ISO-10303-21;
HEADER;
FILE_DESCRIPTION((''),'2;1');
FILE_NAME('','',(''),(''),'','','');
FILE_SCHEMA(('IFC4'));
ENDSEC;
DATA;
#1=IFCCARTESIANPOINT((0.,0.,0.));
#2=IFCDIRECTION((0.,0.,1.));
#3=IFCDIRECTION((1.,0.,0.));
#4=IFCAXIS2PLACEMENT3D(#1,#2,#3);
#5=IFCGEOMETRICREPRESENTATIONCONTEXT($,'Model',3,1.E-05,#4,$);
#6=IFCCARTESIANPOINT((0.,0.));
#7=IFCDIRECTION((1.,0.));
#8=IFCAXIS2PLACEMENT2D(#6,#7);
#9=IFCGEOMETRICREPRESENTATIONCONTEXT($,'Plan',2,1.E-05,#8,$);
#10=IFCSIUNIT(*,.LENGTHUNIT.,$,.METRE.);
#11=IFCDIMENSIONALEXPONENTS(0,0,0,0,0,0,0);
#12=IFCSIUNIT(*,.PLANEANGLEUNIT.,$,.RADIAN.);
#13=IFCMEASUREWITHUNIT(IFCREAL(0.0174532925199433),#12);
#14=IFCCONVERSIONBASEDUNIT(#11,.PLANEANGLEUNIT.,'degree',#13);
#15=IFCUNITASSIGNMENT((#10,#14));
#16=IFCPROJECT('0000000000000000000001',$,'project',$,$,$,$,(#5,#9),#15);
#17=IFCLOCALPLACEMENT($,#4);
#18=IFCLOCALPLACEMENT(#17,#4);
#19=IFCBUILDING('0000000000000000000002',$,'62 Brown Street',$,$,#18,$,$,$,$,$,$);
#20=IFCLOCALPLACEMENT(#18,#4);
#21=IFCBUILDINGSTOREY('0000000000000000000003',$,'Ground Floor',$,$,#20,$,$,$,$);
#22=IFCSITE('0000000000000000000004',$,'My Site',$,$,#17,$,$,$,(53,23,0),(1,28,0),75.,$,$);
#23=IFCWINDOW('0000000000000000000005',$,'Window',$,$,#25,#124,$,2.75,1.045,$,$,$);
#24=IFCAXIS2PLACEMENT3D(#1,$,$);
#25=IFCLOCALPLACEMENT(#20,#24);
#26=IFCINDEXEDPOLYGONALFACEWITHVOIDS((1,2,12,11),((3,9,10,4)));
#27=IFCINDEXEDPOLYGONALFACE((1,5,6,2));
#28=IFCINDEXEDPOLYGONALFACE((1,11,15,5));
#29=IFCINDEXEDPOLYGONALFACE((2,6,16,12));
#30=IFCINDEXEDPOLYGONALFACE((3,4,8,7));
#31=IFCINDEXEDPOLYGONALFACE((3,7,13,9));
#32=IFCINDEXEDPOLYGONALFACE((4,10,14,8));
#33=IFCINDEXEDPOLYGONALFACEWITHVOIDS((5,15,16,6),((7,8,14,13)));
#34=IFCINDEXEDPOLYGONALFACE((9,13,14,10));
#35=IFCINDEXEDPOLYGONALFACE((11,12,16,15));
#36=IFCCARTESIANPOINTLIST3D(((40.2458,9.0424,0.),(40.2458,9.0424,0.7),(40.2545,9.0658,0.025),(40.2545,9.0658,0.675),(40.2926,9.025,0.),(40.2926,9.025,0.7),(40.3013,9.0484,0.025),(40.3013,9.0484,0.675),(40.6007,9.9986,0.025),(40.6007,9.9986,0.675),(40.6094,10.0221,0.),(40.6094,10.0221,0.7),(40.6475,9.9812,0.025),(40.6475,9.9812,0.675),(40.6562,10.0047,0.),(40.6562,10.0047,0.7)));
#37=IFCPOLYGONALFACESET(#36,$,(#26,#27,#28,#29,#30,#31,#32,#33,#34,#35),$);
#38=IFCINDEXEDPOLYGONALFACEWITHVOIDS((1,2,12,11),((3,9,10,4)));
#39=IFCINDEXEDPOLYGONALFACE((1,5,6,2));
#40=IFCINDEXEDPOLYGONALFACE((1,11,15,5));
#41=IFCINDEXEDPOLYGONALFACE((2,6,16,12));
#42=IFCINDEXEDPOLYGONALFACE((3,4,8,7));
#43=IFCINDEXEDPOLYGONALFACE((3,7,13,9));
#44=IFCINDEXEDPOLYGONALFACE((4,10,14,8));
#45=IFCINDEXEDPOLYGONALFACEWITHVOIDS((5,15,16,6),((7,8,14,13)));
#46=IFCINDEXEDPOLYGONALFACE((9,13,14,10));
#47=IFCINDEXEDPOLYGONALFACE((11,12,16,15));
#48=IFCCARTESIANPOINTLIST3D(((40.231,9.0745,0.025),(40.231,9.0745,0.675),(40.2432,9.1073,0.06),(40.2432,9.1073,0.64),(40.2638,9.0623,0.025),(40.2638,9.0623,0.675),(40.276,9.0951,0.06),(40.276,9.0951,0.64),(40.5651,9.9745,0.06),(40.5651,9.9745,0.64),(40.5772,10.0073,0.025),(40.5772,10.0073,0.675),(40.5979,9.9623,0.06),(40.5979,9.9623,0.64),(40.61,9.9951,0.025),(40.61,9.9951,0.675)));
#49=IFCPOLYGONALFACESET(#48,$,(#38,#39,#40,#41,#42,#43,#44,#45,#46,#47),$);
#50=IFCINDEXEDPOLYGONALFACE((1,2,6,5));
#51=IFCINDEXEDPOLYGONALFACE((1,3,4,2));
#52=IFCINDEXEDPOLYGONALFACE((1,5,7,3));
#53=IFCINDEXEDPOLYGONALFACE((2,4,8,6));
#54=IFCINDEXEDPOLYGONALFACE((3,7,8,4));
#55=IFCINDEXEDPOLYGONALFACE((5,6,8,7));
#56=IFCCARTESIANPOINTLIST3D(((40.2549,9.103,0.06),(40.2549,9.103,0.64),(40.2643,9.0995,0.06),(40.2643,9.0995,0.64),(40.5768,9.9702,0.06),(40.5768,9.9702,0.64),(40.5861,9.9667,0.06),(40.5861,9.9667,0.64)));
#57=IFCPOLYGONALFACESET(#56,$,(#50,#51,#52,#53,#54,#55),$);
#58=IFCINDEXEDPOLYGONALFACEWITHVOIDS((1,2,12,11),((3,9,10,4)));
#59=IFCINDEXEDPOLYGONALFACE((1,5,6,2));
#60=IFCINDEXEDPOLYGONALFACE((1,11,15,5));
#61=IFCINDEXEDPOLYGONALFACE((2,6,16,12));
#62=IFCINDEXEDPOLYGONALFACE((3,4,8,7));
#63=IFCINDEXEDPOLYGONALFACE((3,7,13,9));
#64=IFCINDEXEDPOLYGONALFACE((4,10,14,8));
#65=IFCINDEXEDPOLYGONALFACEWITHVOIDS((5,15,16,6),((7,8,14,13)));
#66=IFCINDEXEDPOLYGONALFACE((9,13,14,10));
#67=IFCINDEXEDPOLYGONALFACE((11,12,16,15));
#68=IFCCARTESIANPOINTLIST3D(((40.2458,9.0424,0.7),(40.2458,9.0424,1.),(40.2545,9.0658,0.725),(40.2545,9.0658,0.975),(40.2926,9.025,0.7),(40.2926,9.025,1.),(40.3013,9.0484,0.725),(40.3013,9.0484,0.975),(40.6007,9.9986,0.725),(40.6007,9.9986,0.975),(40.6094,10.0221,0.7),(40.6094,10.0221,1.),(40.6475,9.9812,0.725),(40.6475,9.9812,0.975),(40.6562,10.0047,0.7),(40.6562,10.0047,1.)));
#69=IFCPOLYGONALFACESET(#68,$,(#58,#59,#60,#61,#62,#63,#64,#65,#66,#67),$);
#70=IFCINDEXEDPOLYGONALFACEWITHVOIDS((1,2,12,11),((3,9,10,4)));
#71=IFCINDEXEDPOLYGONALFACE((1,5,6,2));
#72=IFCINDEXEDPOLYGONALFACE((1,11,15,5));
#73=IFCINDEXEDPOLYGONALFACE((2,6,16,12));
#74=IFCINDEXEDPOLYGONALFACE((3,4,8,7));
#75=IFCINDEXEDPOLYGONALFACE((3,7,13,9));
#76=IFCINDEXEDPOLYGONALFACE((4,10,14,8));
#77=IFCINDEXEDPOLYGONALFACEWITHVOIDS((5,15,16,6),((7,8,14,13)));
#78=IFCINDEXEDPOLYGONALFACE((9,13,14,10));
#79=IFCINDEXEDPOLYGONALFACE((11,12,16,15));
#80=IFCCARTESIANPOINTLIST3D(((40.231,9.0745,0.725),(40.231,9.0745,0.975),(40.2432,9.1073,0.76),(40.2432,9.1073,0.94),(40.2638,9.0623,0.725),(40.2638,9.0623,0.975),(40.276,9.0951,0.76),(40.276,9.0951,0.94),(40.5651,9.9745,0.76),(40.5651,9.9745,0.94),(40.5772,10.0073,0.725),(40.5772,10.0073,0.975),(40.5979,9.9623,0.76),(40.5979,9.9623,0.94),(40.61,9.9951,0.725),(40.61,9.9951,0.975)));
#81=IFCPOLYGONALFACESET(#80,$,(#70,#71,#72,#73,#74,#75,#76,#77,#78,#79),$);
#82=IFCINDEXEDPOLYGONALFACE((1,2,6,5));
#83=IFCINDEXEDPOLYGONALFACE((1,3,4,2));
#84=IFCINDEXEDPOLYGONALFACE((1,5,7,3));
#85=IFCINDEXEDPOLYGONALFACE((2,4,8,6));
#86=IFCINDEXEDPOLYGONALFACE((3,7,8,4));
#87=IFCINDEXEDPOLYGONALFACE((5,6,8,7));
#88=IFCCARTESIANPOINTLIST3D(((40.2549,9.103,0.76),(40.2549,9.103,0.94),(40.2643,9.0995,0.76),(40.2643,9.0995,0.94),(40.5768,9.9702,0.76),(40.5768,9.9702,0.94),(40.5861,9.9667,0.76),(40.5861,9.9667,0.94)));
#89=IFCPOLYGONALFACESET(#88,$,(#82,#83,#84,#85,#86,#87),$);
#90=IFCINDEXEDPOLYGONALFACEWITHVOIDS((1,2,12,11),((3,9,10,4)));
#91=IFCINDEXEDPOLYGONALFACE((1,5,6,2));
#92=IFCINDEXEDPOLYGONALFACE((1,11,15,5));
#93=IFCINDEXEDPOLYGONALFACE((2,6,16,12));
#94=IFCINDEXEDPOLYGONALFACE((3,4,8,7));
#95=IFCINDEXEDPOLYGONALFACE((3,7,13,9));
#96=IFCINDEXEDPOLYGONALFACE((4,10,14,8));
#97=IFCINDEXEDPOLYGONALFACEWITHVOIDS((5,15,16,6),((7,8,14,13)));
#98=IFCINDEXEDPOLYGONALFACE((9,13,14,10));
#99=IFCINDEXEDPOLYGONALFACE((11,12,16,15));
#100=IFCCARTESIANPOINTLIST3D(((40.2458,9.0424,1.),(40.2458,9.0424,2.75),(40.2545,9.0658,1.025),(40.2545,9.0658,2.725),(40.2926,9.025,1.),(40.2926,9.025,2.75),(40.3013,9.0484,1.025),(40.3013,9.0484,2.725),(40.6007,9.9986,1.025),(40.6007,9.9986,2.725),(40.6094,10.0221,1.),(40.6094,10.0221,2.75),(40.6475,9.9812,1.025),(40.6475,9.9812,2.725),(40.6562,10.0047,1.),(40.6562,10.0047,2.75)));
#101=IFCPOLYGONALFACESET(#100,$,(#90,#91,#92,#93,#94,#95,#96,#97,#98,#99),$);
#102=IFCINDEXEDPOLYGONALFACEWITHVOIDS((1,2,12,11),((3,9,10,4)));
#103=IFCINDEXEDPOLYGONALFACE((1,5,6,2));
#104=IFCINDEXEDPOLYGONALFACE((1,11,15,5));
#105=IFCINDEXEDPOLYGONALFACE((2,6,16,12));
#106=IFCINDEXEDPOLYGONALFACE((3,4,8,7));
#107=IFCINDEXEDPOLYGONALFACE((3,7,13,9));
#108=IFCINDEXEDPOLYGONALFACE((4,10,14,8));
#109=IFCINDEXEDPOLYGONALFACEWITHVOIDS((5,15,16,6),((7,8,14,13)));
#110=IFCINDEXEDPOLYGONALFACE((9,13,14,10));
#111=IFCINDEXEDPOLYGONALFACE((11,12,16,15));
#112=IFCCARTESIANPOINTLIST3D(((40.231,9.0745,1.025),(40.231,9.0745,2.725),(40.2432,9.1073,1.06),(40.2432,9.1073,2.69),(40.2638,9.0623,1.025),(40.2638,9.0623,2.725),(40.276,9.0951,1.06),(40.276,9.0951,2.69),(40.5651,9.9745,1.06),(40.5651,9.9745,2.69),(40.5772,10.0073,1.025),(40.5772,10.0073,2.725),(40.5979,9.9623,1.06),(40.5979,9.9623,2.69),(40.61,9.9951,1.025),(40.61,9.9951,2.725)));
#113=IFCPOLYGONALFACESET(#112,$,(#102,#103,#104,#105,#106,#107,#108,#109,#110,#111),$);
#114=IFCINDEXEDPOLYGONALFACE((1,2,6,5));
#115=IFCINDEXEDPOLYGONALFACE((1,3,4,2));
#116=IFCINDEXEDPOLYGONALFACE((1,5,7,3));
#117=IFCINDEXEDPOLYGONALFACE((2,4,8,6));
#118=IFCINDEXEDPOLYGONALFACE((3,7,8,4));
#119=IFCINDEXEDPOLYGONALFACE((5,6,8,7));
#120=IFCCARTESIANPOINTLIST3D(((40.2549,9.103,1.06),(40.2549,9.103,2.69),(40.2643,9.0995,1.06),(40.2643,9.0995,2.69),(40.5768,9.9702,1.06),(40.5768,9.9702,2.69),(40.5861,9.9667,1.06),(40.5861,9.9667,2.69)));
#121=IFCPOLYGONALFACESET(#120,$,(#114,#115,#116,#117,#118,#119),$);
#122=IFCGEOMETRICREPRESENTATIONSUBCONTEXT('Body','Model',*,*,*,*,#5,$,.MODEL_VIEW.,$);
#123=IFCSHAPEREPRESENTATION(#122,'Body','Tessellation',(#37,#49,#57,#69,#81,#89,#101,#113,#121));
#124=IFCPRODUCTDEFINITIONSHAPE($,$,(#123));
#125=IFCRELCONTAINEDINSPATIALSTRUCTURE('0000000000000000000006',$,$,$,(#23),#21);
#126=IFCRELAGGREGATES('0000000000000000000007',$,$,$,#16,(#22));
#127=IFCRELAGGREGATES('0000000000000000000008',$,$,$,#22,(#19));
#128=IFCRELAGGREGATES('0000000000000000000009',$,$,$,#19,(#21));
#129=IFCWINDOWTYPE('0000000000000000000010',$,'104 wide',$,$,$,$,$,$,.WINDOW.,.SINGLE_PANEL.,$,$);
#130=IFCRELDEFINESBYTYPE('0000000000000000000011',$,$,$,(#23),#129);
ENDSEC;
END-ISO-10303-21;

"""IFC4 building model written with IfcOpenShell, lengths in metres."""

from ifc_helpers import new_model, entity, si_unit, converted_unit, frame, origin_with_axes, origin_2d_with_axis, place, context, subcontext, project, spatial, line, indexed_curve, outline, extrude, shape, source, transform, mapped, type_object, type_shapes, element, save


model = new_model("IFC4")

# Units and contexts
model_context = context("Model", 3, precision=1e-05, world=origin_with_axes())
plan_context = context("Plan", 2, precision=1e-05, world=origin_2d_with_axis())
body_context_1 = subcontext(model_context, "Body", "Model", "MODEL_VIEW")
body_context_2 = subcontext(plan_context, "Body", "Plan", "PLAN_VIEW")
ifc_project = project(units=[si_unit("LENGTHUNIT", "METRE"), converted_unit("PLANEANGLEUNIT", "degree", entity("IfcReal", 0.0174532925199433), si_unit("PLANEANGLEUNIT", "RADIAN"), dimensions=[0, 0, 0, 0, 0, 0, 0])], contexts=[model_context, plan_context])

# Site, building, storey
site_placement = place(None, origin_with_axes())
site = spatial("IfcSite", under=ifc_project, at=site_placement, Name="My Site", RefLatitude=(53, 23, 0), RefLongitude=(1, 28, 0), RefElevation=75.0)
building_placement = place(site_placement, origin_with_axes())
building = spatial("IfcBuilding", under=site, at=building_placement, Name="62 Brown Street")
storey_placement = place(building_placement, origin_with_axes())
storey = spatial("IfcBuildingStorey", under=building, at=storey_placement, Name="Ground Floor")

# Window
window_type_1 = type_object("IfcWindowType", Name="104 wide", PartitioningType="SINGLE_PANEL", PredefinedType="WINDOW")
shared_shape_1 = source(origin_with_axes(), body_context_1, "Body", "SweptSolid", [
    extrude(outline(indexed_curve([(0.0, 0.0), (1.045, 0.0), (1.045, 0.7), (0.0, 0.7)], segments=[line(1, 2, 3, 4, 1)]), holes=[indexed_curve([(0.025, 0.025), (1.02, 0.025), (1.02, 0.675), (0.025, 0.675)], segments=[line(1, 2, 3, 4, 1)])]), frame((0.0, 0.15, 0.0), z_axis=(0.0, -1.0, 0.0), x_axis=(1.0, 0.0, 0.0)), (0.0, 0.0, -1.0), 0.05),
    extrude(outline(indexed_curve([(0.0, 0.0), (0.995, 0.0), (0.995, 0.65), (0.0, 0.65)], segments=[line(1, 2, 3, 4, 1)]), holes=[indexed_curve([(0.035, 0.035), (0.96, 0.035), (0.96, 0.615), (0.035, 0.615)], segments=[line(1, 2, 3, 4, 1)])]), frame((0.025, 0.19, 0.025), z_axis=(0.0, -1.0, 0.0), x_axis=(1.0, 0.0, 0.0)), (0.0, 0.0, -1.0), 0.035),
    extrude(outline(indexed_curve([(0.035, 0.035), (0.96, 0.035), (0.96, 0.615), (0.035, 0.615)], segments=[line(1, 2, 3, 4, 1)])), frame((0.025, 0.2025, 0.025), z_axis=(0.0, -1.0, 0.0), x_axis=(1.0, 0.0, 0.0)), (0.0, 0.0, -1.0), 0.01),
    extrude(outline(indexed_curve([(0.0, 0.0), (1.045, 0.0), (1.045, 0.3), (0.0, 0.3)], segments=[line(1, 2, 3, 4, 1)]), holes=[indexed_curve([(0.025, 0.025), (1.02, 0.025), (1.02, 0.275), (0.025, 0.275)], segments=[line(1, 2, 3, 4, 1)])]), frame((0.0, 0.15, 0.7), z_axis=(0.0, -1.0, 0.0), x_axis=(1.0, 0.0, 0.0)), (0.0, 0.0, -1.0), 0.05),
    extrude(outline(indexed_curve([(0.0, 0.0), (0.995, 0.0), (0.995, 0.25), (0.0, 0.25)], segments=[line(1, 2, 3, 4, 1)]), holes=[indexed_curve([(0.035, 0.035), (0.96, 0.035), (0.96, 0.215), (0.035, 0.215)], segments=[line(1, 2, 3, 4, 1)])]), frame((0.025, 0.19, 0.725), z_axis=(0.0, -1.0, 0.0), x_axis=(1.0, 0.0, 0.0)), (0.0, 0.0, -1.0), 0.035),
    extrude(outline(indexed_curve([(0.035, 0.035), (0.96, 0.035), (0.96, 0.215), (0.035, 0.215)], segments=[line(1, 2, 3, 4, 1)])), frame((0.025, 0.2025, 0.725), z_axis=(0.0, -1.0, 0.0), x_axis=(1.0, 0.0, 0.0)), (0.0, 0.0, -1.0), 0.01),
    extrude(outline(indexed_curve([(0.0, 0.0), (1.045, 0.0), (1.045, 1.75), (0.0, 1.75)], segments=[line(1, 2, 3, 4, 1)]), holes=[indexed_curve([(0.025, 0.025), (1.02, 0.025), (1.02, 1.725), (0.025, 1.725)], segments=[line(1, 2, 3, 4, 1)])]), frame((0.0, 0.15, 1.0), z_axis=(0.0, -1.0, 0.0), x_axis=(1.0, 0.0, 0.0)), (0.0, 0.0, -1.0), 0.05),
    extrude(outline(indexed_curve([(0.0, 0.0), (0.995, 0.0), (0.995, 1.7), (0.0, 1.7)], segments=[line(1, 2, 3, 4, 1)]), holes=[indexed_curve([(0.035, 0.035), (0.96, 0.035), (0.96, 1.665), (0.035, 1.665)], segments=[line(1, 2, 3, 4, 1)])]), frame((0.025, 0.19, 1.025), z_axis=(0.0, -1.0, 0.0), x_axis=(1.0, 0.0, 0.0)), (0.0, 0.0, -1.0), 0.035),
    extrude(outline(indexed_curve([(0.035, 0.035), (0.96, 0.035), (0.96, 1.665), (0.035, 1.665)], segments=[line(1, 2, 3, 4, 1)])), frame((0.025, 0.2025, 1.025), z_axis=(0.0, -1.0, 0.0), x_axis=(1.0, 0.0, 0.0)), (0.0, 0.0, -1.0), 0.01),
])
shared_shape_2 = source(origin_with_axes(), body_context_2, "Body", "Curve2D", [
    entity("IfcIndexedPolyCurve", entity("IfcCartesianPointList2D", [[0.025, 0.15], [1.02, 0.15]])),
    entity("IfcIndexedPolyCurve", entity("IfcCartesianPointList2D", [[0.0, 0.2], [0.025, 0.2], [0.025, 0.15], [0.0, 0.15]]), [entity("IfcLineIndex", [1, 2, 3, 4, 1])]),
    entity("IfcIndexedPolyCurve", entity("IfcCartesianPointList2D", [[1.045, 0.2], [1.02, 0.2], [1.02, 0.15], [1.045, 0.15]]), [entity("IfcLineIndex", [1, 2, 3, 4, 1])]),
    entity("IfcIndexedPolyCurve", entity("IfcCartesianPointList2D", [[0.025, 0.19], [0.06, 0.19], [0.06, 0.225], [0.025, 0.225]]), [entity("IfcLineIndex", [1, 2, 3, 4, 1])]),
    entity("IfcIndexedPolyCurve", entity("IfcCartesianPointList2D", [[1.02, 0.19], [0.985, 0.19], [0.985, 0.225], [1.02, 0.225]]), [entity("IfcLineIndex", [1, 2, 3, 4, 1])]),
    entity("IfcIndexedPolyCurve", entity("IfcCartesianPointList2D", [[0.06, 0.19], [0.985, 0.19]])),
    entity("IfcIndexedPolyCurve", entity("IfcCartesianPointList2D", [[0.06, 0.225], [0.985, 0.225]])),
    entity("IfcIndexedPolyCurve", entity("IfcCartesianPointList2D", [[0.06, 0.2075], [0.985, 0.2075]])),
])
type_shapes(window_type_1, [shared_shape_1, shared_shape_2])
placement_1 = place(storey_placement, frame((39.024, 5.1755, 0.0), z_axis=(0.0, 0.0, 1.0), x_axis=(0.347944, 0.937515, 0.0)))
placement_2 = place(placement_1, frame((4.0504, 0.0, 0.0), z_axis=(0.0, 0.0, 1.0), x_axis=(1.0, 0.0, 0.0)))
window_1_placement = place(placement_2, frame((0.0, 0.0, 0.0), z_axis=(0.0, 0.0, 1.0), x_axis=(1.0, 0.0, 0.0)))
element("IfcWindow", 1, at=window_1_placement, inside=storey, type_object=window_type_1, Name="Window", OverallHeight=2.75, OverallWidth=1.045, shapes=[
    shape(body_context_1, "Body", "MappedRepresentation", [mapped(shared_shape_1, transform((0.0, 0.0, 0.0), x_axis=(1.0, 0.0, 0.0), y_axis=(0.0, 1.0, 0.0), z_axis=(0.0, 0.0, 1.0), scale=1.0))]),
    shape(body_context_2, "Body", "MappedRepresentation", [mapped(shared_shape_2, transform((0.0, 0.0, 0.0), x_axis=(1.0, 0.0, 0.0), y_axis=(0.0, 1.0, 0.0), z_axis=(0.0, 0.0, 1.0), scale=1.0))]),
])

save(model, "model.ifc")
